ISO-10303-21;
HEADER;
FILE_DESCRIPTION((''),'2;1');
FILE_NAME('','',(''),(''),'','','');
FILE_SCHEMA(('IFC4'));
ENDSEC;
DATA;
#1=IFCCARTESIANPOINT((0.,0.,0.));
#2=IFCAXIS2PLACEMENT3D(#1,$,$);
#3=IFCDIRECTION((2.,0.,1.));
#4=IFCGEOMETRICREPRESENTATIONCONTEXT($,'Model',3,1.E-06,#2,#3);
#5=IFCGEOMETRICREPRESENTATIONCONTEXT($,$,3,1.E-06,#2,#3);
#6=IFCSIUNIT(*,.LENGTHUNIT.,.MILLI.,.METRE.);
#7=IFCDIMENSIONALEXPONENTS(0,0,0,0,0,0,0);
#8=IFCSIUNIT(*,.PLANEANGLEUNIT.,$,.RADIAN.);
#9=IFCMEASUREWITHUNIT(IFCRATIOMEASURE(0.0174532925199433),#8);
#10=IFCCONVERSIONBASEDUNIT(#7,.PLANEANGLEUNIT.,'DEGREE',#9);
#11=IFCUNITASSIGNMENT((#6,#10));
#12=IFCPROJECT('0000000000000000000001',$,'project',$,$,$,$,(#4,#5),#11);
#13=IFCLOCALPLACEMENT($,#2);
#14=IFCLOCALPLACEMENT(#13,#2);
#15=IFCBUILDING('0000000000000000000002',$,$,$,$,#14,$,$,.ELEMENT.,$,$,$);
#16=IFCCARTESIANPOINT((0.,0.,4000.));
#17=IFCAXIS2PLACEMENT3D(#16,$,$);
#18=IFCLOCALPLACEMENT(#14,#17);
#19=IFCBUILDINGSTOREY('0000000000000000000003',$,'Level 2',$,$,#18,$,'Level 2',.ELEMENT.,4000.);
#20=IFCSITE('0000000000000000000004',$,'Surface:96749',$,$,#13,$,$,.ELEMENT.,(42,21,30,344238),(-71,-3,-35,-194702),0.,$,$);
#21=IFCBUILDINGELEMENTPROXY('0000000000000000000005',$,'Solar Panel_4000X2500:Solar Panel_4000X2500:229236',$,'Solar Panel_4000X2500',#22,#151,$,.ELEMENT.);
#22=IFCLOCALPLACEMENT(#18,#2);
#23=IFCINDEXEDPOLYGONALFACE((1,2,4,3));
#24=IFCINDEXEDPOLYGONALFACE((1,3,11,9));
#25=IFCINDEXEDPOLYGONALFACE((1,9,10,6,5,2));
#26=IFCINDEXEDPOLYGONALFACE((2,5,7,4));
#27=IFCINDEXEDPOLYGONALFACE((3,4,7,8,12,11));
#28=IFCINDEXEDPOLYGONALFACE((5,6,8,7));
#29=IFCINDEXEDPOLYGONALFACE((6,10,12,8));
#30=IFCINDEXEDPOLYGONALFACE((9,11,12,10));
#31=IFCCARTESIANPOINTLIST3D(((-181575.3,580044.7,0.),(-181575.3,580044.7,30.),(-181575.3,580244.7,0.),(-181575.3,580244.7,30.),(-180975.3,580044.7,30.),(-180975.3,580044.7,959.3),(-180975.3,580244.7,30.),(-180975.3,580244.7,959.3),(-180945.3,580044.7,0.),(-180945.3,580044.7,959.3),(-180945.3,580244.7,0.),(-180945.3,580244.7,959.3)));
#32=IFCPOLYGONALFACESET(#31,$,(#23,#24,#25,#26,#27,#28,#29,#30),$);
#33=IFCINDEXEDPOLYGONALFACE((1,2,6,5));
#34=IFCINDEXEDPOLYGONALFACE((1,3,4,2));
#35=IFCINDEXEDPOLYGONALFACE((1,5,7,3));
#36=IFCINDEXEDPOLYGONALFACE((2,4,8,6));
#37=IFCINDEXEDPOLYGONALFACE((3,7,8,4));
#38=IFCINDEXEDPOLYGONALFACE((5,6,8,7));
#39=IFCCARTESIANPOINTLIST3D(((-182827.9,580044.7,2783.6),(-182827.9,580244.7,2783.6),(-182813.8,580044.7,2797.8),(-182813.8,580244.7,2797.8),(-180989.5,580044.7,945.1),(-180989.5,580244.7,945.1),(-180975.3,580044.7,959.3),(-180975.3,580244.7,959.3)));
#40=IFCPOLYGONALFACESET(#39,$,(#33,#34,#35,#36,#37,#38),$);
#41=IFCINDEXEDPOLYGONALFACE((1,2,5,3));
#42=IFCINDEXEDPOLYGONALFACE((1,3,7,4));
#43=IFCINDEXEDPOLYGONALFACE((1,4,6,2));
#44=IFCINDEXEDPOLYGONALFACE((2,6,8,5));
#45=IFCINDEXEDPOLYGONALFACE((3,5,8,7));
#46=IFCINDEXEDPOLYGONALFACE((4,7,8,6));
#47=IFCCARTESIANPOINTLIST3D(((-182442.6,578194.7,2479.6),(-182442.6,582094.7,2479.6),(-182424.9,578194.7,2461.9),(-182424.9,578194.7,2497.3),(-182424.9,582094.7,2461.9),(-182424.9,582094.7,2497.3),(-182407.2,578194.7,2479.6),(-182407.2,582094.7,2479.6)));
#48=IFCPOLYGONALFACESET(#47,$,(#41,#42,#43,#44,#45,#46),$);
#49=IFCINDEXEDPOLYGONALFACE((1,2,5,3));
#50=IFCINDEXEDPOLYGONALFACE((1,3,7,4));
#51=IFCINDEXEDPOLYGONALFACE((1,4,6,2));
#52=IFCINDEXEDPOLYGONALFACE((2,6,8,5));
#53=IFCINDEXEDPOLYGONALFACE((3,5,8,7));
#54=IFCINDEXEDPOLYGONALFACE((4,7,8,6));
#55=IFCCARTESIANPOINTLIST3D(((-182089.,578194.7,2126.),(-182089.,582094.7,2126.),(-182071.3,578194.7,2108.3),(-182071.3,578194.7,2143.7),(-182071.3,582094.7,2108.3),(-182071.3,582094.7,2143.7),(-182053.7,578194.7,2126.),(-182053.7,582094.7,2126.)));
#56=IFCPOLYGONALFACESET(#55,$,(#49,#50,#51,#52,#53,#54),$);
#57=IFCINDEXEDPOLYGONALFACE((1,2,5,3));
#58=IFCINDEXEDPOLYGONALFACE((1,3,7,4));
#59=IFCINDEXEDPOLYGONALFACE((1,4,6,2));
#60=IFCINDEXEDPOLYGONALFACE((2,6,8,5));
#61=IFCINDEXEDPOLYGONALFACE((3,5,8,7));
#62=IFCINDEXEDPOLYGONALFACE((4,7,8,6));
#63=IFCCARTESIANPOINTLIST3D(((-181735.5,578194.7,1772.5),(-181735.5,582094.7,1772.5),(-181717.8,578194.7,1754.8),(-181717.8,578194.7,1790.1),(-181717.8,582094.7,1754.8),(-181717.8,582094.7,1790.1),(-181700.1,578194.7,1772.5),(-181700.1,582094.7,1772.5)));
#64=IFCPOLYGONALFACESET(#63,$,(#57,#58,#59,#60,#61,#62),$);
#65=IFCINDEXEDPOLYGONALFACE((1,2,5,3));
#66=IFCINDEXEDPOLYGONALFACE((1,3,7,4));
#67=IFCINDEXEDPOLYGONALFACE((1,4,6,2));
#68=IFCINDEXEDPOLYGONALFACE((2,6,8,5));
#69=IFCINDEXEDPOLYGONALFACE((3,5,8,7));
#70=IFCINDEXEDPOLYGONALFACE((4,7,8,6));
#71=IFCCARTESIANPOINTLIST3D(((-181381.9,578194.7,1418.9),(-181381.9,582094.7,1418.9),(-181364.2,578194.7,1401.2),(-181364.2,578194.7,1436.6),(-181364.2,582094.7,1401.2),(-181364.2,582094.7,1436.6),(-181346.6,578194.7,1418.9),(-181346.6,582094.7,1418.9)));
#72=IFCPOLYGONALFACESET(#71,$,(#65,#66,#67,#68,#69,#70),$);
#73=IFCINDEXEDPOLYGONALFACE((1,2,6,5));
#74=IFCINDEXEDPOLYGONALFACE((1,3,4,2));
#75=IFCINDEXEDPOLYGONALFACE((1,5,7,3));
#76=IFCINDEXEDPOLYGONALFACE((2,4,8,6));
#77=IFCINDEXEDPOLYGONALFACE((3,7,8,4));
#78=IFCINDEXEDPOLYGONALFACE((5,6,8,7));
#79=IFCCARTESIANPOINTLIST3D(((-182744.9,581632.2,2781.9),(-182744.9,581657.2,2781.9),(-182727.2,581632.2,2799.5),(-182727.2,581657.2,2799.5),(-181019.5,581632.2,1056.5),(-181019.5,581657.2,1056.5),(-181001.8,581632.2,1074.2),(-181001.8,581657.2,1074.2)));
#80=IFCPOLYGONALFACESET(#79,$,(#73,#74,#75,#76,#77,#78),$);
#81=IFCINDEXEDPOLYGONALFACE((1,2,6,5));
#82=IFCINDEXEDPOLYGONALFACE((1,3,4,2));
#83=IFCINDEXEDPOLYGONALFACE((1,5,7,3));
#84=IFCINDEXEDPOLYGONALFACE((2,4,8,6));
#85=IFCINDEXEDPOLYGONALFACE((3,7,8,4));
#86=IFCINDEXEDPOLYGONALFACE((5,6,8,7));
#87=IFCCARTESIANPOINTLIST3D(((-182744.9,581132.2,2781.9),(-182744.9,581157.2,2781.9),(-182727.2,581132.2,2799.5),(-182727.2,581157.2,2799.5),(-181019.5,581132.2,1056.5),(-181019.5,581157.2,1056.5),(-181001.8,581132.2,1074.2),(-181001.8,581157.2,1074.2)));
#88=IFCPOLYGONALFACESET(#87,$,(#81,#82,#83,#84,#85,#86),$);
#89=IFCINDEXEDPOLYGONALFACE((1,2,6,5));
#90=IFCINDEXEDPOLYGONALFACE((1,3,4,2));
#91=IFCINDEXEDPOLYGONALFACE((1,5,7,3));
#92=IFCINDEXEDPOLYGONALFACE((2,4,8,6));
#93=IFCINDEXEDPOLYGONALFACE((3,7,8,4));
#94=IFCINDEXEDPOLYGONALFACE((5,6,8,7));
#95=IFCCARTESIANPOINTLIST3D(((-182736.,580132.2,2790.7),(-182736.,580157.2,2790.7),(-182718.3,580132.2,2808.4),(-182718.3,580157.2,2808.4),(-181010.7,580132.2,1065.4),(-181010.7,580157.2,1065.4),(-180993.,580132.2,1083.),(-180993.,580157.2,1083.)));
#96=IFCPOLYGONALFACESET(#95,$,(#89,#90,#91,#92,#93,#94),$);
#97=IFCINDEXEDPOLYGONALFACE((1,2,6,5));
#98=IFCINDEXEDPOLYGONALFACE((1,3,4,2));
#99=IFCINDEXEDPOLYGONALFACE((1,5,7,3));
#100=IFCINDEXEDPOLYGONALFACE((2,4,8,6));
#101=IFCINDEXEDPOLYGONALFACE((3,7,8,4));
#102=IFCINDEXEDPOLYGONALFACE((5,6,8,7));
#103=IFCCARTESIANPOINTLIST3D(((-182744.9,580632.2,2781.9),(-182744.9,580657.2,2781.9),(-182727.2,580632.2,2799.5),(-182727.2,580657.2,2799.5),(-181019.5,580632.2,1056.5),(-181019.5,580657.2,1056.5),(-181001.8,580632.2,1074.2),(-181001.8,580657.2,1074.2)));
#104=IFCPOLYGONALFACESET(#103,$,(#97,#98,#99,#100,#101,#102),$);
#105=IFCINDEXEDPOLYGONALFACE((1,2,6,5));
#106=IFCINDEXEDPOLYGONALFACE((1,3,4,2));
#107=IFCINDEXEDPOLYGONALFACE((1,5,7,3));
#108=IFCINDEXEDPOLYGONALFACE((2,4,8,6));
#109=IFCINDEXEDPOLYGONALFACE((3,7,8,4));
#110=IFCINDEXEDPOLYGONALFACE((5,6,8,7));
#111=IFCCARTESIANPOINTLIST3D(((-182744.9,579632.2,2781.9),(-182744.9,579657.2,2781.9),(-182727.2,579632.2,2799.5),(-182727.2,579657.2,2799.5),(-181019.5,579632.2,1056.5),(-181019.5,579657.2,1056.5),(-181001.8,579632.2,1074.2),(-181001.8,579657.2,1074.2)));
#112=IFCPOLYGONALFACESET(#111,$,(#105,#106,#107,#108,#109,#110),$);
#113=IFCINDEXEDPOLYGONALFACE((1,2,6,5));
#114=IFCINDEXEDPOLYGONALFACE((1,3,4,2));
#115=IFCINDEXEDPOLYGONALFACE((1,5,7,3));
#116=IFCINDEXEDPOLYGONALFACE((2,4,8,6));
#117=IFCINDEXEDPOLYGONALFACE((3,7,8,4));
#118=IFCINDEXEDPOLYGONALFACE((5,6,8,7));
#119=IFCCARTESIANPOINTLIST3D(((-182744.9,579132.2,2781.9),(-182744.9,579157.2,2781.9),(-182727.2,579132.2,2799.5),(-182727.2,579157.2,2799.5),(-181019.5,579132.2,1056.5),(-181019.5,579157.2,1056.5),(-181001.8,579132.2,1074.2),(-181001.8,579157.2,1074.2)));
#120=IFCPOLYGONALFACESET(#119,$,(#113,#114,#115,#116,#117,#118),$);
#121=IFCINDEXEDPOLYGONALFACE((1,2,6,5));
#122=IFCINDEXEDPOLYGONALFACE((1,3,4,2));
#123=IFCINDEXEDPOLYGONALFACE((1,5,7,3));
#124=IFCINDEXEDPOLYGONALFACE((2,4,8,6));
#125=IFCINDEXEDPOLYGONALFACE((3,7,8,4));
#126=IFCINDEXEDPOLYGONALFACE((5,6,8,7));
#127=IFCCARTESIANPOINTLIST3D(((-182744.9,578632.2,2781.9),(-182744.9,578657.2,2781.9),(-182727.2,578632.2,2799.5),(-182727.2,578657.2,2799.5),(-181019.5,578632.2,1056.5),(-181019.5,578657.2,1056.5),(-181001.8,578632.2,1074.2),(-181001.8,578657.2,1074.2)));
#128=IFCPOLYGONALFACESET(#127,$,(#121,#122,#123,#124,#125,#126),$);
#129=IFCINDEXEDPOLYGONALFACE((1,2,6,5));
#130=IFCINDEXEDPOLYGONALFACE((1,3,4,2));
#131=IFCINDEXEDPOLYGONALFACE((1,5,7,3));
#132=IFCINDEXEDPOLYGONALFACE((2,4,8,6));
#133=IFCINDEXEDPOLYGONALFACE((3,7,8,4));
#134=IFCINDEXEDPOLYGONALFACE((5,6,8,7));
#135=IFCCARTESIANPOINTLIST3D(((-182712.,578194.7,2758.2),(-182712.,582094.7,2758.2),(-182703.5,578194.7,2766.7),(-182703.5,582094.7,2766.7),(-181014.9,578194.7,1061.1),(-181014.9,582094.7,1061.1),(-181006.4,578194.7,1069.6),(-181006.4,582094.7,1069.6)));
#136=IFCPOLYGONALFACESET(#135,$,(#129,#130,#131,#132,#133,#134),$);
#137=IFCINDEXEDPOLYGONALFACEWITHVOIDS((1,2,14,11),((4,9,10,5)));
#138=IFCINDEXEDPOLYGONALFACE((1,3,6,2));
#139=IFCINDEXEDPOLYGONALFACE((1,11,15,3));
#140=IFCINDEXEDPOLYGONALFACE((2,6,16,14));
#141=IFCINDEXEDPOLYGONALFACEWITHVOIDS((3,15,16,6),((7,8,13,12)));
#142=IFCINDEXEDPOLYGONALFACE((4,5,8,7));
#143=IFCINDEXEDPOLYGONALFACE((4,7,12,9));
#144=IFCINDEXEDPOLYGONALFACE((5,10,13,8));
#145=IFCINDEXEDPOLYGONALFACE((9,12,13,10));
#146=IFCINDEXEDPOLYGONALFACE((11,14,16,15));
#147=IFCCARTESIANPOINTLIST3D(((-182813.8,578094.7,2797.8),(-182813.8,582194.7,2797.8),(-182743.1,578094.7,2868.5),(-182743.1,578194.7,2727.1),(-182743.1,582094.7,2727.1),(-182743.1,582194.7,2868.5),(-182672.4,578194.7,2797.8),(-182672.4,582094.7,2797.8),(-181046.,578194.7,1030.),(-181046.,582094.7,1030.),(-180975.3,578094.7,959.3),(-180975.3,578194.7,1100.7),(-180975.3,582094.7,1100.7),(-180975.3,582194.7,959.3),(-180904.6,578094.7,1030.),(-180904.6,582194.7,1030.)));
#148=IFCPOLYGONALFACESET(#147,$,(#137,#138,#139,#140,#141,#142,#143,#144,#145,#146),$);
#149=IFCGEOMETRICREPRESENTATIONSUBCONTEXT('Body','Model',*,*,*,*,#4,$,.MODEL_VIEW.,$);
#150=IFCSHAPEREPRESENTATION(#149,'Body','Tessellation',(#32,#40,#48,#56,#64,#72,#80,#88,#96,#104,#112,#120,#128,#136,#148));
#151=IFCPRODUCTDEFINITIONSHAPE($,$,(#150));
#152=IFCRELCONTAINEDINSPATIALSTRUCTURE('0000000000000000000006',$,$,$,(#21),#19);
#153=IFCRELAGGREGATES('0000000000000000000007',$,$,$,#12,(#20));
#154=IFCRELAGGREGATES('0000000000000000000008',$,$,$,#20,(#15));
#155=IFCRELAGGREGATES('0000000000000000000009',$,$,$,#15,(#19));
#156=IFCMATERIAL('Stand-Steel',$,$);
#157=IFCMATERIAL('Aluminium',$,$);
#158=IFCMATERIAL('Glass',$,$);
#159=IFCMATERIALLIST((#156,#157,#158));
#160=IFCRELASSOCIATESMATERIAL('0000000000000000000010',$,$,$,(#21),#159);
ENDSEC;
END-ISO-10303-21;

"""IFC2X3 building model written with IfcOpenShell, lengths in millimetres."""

from ifc_helpers import new_model, entity, si_unit, converted_unit, direction, frame, frame_2d, origin, origin_2d_with_axis, place, context, subcontext, project, spatial, polyline, rectangle, outline, extrude, source, transform, mapped, material, material_list, element, save


model = new_model("IFC2X3")

# Units and contexts
model_context = context("Model", 3, precision=1e-06, world=origin(), true_north=direction((2.0, 0.0, 1.0)))
context_of_model = context(None, 3, precision=1e-06, world=origin(), true_north=direction((2.0, 0.0, 1.0)))
body_context = subcontext(model_context, "Body", "Model", "MODEL_VIEW")
ifc_project = project(units=[si_unit("LENGTHUNIT", "METRE", prefix="MILLI"), converted_unit("PLANEANGLEUNIT", "DEGREE", entity("IfcRatioMeasure", 0.0174532925199433), si_unit("PLANEANGLEUNIT", "RADIAN"), dimensions=[0, 0, 0, 0, 0, 0, 0])], contexts=[model_context, context_of_model])

# Site, building, storey
site_placement = place(None, origin())
site = spatial("IfcSite", under=ifc_project, at=site_placement, Name="Surface:96749", CompositionType="ELEMENT", RefLatitude=(42, 21, 30, 344238), RefLongitude=(-71, -3, -35, -194702), RefElevation=0.0)
building_placement = place(site_placement, origin())
building = spatial("IfcBuilding", under=site, at=building_placement, CompositionType="ELEMENT")
storey_placement = place(building_placement, frame((0.0, 0.0, 4000.0)))
storey = spatial("IfcBuildingStorey", under=building, at=storey_placement, Name="Level 2", LongName="Level 2", CompositionType="ELEMENT", Elevation=4000.0)

# Building element proxy
ifc_material_1 = material(Name="Stand-Steel")
ifc_material_2 = material(Name="Aluminium")
ifc_material_3 = material(Name="Glass")
shared_shape = source(origin(), body_context, "Body", "SweptSolid", [
    extrude(outline(polyline([(-629.5, -220.0), (329.8, -220.0), (329.8, 410.0), (299.8, 410.0), (299.8, -190.0), (-629.5, -190.0), (-629.5, -220.0)])), frame((-190.0, -100.0, 299.8), z_axis=(0.0, 1.0, 0.0), x_axis=(0.0, 0.0, -1.0)), (0.0, 0.0, 1.0), 200.0),
    extrude(rectangle(XDim=20.0, YDim=200.0, at=frame_2d((0.0, 0.0), x_axis=(0.0, 1.0))), frame((-7.1, 0.0, 922.2), z_axis=(-0.707107, 0.0, 0.707107), x_axis=(0.0, 1.0, 0.0)), (0.0, 0.0, 1.0), 2600.0),
    extrude(rectangle(XDim=25.0, YDim=25.0, at=frame_2d((0.0, 0.0), x_axis=(1.0, 0.0))), frame((-1449.6, -1950.0, 2449.6), z_axis=(0.0, 1.0, 0.0), x_axis=(-0.707107, 0.0, -0.707107)), (0.0, 0.0, 1.0), 3900.0),
    extrude(rectangle(XDim=25.0, YDim=25.0, at=origin_2d_with_axis()), frame((-1096.0, -1950.0, 2096.0), z_axis=(0.0, 1.0, 0.0), x_axis=(-0.707107, 0.0, -0.707107)), (0.0, 0.0, 1.0), 3900.0),
    extrude(rectangle(XDim=25.0, YDim=25.0, at=origin_2d_with_axis()), frame((-742.5, -1950.0, 1742.5), z_axis=(0.0, 1.0, 0.0), x_axis=(-0.707107, 0.0, -0.707107)), (0.0, 0.0, 1.0), 3900.0),
    extrude(rectangle(XDim=25.0, YDim=25.0, at=frame_2d((0.0, 0.0), x_axis=(1.0, 0.0))), frame((-388.9, -1950.0, 1388.9), z_axis=(0.0, 1.0, 0.0), x_axis=(-0.707107, 0.0, -0.707107)), (0.0, 0.0, 1.0), 3900.0),
    extrude(rectangle(XDim=25.0, YDim=25.0, at=frame_2d((0.0, 0.0), x_axis=(0.0, 1.0))), frame((-35.4, 1500.0, 1035.4), z_axis=(-0.707107, 0.0, 0.707107), x_axis=(0.0, 1.0, 0.0)), (0.0, 0.0, 1.0), 2440.0),
    extrude(rectangle(XDim=25.0, YDim=25.0, at=frame_2d((0.0, 0.0), x_axis=(0.0, 1.0))), frame((-35.4, 1000.0, 1035.4), z_axis=(-0.707107, 0.0, 0.707107), x_axis=(0.0, 1.0, 0.0)), (0.0, 0.0, 1.0), 2440.0),
    extrude(rectangle(XDim=25.0, YDim=25.0, at=frame_2d((0.0, 0.0), x_axis=(0.0, 1.0))), frame((-26.5, 0.0, 1044.2), z_axis=(-0.707107, 0.0, 0.707107), x_axis=(0.0, -1.0, 0.0)), (0.0, 0.0, 1.0), 2440.0),
    extrude(rectangle(XDim=25.0, YDim=25.0, at=frame_2d((0.0, 0.0), x_axis=(0.0, 1.0))), frame((-35.4, 500.0, 1035.4), z_axis=(-0.707107, 0.0, 0.707107), x_axis=(0.0, 1.0, 0.0)), (0.0, 0.0, 1.0), 2440.0),
    extrude(rectangle(XDim=25.0, YDim=25.0, at=frame_2d((0.0, 0.0), x_axis=(0.0, 1.0))), frame((-35.4, -500.0, 1035.4), z_axis=(-0.707107, 0.0, 0.707107), x_axis=(0.0, 1.0, 0.0)), (0.0, 0.0, 1.0), 2440.0),
    extrude(rectangle(XDim=25.0, YDim=25.0, at=frame_2d((0.0, 0.0), x_axis=(0.0, 1.0))), frame((-35.4, -1000.0, 1035.4), z_axis=(-0.707107, 0.0, 0.707107), x_axis=(0.0, 1.0, 0.0)), (0.0, 0.0, 1.0), 2440.0),
    extrude(rectangle(XDim=25.0, YDim=25.0, at=frame_2d((0.0, 0.0), x_axis=(0.0, 1.0))), frame((-35.4, -1500.0, 1035.4), z_axis=(-0.707107, 0.0, 0.707107), x_axis=(0.0, 1.0, 0.0)), (0.0, 0.0, 1.0), 2440.0),
    extrude(rectangle(XDim=2400.0, YDim=12.0, at=frame_2d((0.0, 0.0), x_axis=(1.0, 0.0))), frame((-883.9, -1950.0, 1883.9), z_axis=(0.0, 1.0, 0.0), x_axis=(0.707107, 0.0, -0.707107)), (0.0, 0.0, 1.0), 3900.0),
    extrude(outline(polyline([(-2050.0, -1300.0), (2050.0, -1300.0), (2050.0, 1300.0), (-2050.0, 1300.0), (-2050.0, -1300.0)]), holes=[polyline([(1950.0, -1200.0), (-1950.0, -1200.0), (-1950.0, 1200.0), (1950.0, 1200.0), (1950.0, -1200.0)])]), frame((-919.2, 0.0, 1848.5), z_axis=(0.707107, 0.0, 0.707107), x_axis=(0.0, 1.0, 0.0)), (0.0, 0.0, 1.0), 100.0),
])
ifc_material_list_1 = material_list([ifc_material_1, ifc_material_2, ifc_material_3])
proxy_1_placement = place(storey_placement, frame((-180975.3, 580144.7, 30.0)))
element("IfcBuildingElementProxy", 1, at=proxy_1_placement, inside=storey, material=ifc_material_list_1, Name="Solar Panel_4000X2500:Solar Panel_4000X2500:229236", ObjectType="Solar Panel_4000X2500", CompositionType="ELEMENT", context=body_context, shape_type="MappedRepresentation", body=[
    mapped(shared_shape, transform((0.0, 0.0, 0.0), scale=1.0)),
])

save(model, "model.ifc")
